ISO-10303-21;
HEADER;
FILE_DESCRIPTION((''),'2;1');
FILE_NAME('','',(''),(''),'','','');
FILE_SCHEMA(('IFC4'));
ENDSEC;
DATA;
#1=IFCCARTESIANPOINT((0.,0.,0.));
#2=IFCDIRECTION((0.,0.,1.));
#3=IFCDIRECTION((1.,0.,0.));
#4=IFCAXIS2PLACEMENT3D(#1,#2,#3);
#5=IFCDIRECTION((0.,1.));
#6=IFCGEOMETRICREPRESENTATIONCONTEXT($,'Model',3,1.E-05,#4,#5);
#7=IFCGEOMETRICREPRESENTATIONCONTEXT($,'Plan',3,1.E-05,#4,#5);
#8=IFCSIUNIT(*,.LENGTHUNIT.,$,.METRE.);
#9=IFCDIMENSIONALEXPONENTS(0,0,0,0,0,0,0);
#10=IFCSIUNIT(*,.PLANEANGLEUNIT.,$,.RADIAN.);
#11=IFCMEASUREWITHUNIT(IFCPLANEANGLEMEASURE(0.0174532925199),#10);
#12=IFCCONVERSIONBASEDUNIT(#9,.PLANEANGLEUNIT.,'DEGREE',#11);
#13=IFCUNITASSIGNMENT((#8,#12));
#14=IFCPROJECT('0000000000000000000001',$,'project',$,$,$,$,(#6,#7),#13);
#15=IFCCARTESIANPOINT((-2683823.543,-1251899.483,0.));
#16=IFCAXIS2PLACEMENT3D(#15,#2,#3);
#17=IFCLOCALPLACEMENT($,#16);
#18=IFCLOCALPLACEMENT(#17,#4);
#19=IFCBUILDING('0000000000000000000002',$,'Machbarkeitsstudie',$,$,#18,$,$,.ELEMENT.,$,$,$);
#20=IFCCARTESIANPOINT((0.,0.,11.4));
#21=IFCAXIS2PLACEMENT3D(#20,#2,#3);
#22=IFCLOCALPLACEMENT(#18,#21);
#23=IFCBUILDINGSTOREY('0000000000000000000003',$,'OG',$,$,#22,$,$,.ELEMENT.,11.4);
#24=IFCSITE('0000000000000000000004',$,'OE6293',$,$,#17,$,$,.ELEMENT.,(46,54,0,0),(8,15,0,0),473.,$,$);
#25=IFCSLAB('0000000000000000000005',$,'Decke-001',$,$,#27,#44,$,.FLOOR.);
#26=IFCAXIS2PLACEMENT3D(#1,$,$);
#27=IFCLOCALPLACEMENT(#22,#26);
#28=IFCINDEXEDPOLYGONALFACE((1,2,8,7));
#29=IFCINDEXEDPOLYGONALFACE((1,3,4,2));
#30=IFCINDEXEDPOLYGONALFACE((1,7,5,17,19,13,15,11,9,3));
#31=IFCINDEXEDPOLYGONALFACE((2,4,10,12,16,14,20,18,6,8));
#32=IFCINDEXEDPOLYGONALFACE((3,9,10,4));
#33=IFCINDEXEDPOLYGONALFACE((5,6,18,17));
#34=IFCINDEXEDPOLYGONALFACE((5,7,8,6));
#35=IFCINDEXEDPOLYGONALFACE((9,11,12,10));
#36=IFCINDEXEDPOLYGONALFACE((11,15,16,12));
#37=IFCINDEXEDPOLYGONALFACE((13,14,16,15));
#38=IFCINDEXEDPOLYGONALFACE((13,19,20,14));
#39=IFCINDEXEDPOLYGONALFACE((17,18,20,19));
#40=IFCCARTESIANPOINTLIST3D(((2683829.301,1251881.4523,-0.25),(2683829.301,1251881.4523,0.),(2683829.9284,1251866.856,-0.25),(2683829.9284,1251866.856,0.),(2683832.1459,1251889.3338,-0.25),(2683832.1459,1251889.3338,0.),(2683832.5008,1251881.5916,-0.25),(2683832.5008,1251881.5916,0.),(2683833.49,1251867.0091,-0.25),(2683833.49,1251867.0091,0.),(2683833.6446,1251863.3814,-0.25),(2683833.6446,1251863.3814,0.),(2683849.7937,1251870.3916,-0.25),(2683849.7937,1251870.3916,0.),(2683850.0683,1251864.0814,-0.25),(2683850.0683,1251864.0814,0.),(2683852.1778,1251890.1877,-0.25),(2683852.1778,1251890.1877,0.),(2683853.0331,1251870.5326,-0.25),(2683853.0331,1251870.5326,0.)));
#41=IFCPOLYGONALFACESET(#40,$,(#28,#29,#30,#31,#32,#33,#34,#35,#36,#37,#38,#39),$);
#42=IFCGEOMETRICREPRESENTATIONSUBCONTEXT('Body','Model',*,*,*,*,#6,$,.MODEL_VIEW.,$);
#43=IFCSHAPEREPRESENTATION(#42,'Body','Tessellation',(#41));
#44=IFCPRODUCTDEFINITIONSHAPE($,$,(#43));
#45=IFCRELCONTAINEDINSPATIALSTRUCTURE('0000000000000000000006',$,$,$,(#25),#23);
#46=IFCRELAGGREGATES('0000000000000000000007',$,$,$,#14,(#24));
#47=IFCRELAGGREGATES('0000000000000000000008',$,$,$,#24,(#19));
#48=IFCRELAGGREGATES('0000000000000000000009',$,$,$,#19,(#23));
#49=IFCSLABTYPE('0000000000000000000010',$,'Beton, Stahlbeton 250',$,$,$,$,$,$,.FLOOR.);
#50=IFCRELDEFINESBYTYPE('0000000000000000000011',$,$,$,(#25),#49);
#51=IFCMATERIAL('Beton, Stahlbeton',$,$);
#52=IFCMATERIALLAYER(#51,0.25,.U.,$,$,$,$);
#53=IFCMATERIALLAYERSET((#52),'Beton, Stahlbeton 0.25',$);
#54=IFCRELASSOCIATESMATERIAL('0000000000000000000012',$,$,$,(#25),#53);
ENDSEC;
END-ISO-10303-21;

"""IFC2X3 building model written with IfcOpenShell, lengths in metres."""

from ifc_helpers import new_model, entity, si_unit, converted_unit, direction, frame, origin_with_axes, place, context, subcontext, project, spatial, polyline, outline, extrude, material, layer, layer_set, layer_usage, type_object, element, save


model = new_model("IFC2X3")

# Units and contexts
model_context = context("Model", 3, precision=1e-05, world=origin_with_axes(), true_north=direction((0.0, 1.0)))
plan_context = context("Plan", 3, precision=1e-05, world=origin_with_axes(), true_north=direction((0.0, 1.0)))
body_context = subcontext(model_context, "Body", "Model", "MODEL_VIEW")
ifc_project = project(units=[si_unit("LENGTHUNIT", "METRE"), converted_unit("PLANEANGLEUNIT", "DEGREE", entity("IfcPlaneAngleMeasure", 0.0174532925199), si_unit("PLANEANGLEUNIT", "RADIAN"), dimensions=[0, 0, 0, 0, 0, 0, 0])], contexts=[model_context, plan_context])

# Site, building, storey
site_placement = place(None, frame((-2683823.543, -1251899.483, 0.0), z_axis=(0.0, 0.0, 1.0), x_axis=(1.0, 0.0, 0.0)))
site = spatial("IfcSite", under=ifc_project, at=site_placement, Name="OE6293", CompositionType="ELEMENT", RefLatitude=(46, 54, 0, 0), RefLongitude=(8, 15, 0, 0), RefElevation=473.0)
building_placement = place(site_placement, origin_with_axes())
building = spatial("IfcBuilding", under=site, at=building_placement, Name="Machbarkeitsstudie", CompositionType="ELEMENT")
storey_placement = place(building_placement, frame((0.0, 0.0, 11.4), z_axis=(0.0, 0.0, 1.0), x_axis=(1.0, 0.0, 0.0)))
storey = spatial("IfcBuildingStorey", under=building, at=storey_placement, Name="OG", CompositionType="ELEMENT", Elevation=11.4)

# Slab
ifc_material = material(Name="Beton, Stahlbeton")
ifc_layer = layer(ifc_material, 0.25, ventilated="UNKNOWN")
ifc_layer_set = layer_set([ifc_layer], Name="Beton, Stahlbeton 0.25")
ifc_layer_usage = layer_usage(ifc_layer_set, "AXIS3", "NEGATIVE", 0.25)
slab_type = type_object("IfcSlabType", Name="Beton, Stahlbeton 250", PredefinedType="FLOOR")
slab_placement = place(storey_placement, frame((2683832.5008, 1251881.5916, 0.0), z_axis=(0.0, 0.0, 1.0), x_axis=(1.0, 0.0, 0.0)))
element("IfcSlab", 1, at=slab_placement, inside=storey, type_object=slab_type, material=ifc_layer_usage, Name="Decke-001", PredefinedType="FLOOR", context=body_context, shape_type="SweptSolid", body=[
    extrude(outline(polyline([(0.0, 0.0), (-3.1998, -0.1392), (-2.5724, -14.7356), (0.9892, -14.5825), (1.1438, -18.2102), (17.5674, -17.5102), (17.2928, -11.2), (20.5323, -11.059), (19.677, 8.5961), (-0.3549, 7.7422), (0.0, 0.0)])), frame((0.0, 0.0, -0.25), z_axis=(0.0, 0.0, 1.0), x_axis=(1.0, 0.0, 0.0)), (0.0, 0.0, 1.0), 0.25),
])

save(model, "model.ifc")
